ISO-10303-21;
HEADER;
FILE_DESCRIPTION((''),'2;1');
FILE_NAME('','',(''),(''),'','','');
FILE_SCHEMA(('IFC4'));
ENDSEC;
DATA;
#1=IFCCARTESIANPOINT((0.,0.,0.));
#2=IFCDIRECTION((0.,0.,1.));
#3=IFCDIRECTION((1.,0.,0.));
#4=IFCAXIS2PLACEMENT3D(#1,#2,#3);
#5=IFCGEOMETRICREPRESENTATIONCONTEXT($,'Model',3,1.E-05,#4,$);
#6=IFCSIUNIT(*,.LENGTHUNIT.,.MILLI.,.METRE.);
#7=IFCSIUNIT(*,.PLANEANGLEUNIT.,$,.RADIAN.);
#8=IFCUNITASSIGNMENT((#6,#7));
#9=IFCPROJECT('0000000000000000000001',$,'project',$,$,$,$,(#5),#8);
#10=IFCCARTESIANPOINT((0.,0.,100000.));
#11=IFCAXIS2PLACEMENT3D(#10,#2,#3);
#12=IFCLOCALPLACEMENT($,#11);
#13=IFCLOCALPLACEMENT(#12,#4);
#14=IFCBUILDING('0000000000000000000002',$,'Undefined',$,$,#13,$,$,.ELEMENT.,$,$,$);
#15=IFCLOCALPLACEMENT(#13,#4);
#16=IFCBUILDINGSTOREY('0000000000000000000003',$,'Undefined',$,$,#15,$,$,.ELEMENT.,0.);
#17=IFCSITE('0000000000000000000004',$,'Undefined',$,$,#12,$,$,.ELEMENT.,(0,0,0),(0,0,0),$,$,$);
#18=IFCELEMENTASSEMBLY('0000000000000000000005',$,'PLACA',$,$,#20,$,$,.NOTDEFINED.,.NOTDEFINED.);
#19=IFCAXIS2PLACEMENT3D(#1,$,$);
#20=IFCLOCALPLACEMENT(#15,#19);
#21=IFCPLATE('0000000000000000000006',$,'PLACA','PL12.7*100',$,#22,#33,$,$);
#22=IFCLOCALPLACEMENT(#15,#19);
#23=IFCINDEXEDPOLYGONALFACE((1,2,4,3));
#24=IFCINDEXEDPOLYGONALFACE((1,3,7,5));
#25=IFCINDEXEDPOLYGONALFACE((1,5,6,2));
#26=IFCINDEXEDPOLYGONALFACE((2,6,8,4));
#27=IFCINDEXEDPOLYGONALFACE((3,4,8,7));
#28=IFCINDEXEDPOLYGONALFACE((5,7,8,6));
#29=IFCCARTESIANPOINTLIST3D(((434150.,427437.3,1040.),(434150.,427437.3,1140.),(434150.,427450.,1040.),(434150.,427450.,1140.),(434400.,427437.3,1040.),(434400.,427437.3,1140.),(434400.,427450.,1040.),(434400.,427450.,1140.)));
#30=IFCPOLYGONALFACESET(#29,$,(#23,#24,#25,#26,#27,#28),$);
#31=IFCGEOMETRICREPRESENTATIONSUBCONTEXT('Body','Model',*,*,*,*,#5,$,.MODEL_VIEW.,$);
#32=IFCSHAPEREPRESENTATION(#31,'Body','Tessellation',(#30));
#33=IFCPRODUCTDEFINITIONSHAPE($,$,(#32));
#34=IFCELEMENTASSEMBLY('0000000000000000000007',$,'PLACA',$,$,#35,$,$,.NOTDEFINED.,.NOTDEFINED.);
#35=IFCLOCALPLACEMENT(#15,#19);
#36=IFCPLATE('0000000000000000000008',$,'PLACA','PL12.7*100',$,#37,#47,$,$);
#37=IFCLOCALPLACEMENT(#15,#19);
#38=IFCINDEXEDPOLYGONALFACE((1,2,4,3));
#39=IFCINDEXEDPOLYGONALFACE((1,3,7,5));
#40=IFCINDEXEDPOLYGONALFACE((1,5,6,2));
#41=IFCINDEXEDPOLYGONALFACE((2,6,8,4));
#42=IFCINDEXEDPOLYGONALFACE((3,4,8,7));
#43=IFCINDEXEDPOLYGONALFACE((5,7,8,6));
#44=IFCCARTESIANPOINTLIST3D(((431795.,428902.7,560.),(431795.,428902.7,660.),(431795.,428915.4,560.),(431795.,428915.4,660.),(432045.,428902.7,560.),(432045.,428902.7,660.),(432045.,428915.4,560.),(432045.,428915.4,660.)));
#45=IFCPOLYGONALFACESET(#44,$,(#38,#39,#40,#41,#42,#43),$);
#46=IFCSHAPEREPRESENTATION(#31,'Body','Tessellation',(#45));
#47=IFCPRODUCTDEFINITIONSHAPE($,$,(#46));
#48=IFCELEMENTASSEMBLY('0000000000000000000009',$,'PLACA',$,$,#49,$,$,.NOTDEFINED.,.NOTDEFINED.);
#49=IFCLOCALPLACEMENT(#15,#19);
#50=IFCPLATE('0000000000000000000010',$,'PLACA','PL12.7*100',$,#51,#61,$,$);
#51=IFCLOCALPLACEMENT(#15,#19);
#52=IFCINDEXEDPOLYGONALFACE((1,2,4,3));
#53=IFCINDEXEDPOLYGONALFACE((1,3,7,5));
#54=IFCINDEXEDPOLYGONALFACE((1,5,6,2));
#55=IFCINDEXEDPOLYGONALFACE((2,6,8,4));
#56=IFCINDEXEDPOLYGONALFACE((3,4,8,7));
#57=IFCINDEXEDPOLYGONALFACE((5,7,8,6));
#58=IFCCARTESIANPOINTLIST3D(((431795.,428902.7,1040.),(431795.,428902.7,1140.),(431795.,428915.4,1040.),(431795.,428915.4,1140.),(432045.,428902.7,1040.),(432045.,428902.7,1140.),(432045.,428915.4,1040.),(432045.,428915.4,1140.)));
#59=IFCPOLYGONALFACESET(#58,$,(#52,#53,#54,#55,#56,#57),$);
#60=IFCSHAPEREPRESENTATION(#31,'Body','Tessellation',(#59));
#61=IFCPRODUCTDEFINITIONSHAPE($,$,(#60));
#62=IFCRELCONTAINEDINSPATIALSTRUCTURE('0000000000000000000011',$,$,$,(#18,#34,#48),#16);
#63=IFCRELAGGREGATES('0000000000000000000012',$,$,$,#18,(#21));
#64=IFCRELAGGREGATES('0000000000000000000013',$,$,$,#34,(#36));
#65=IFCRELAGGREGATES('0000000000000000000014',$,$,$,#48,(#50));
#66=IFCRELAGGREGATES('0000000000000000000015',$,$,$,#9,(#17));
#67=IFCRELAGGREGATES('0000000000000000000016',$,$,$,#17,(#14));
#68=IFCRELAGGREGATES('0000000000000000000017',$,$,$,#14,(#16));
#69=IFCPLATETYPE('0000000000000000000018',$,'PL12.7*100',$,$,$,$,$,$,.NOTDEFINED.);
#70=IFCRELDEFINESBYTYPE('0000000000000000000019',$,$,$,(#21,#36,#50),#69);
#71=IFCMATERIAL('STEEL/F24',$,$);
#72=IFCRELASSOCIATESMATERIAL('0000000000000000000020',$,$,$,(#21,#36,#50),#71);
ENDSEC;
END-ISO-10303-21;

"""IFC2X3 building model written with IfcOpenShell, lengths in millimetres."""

from ifc_helpers import new_model, si_unit, frame, origin_with_axes, place, context, subcontext, project, spatial, polyline, outline, extrude, material, type_object, element, aggregate, save


model = new_model("IFC2X3")

# Units and contexts
model_context = context("Model", 3, precision=1e-05, world=origin_with_axes())
body_context = subcontext(model_context, "Body", "Model", "MODEL_VIEW")
ifc_project = project(units=[si_unit("LENGTHUNIT", "METRE", prefix="MILLI"), si_unit("PLANEANGLEUNIT", "RADIAN")], contexts=[model_context])

# Site, building, storey
site_placement = place(None, frame((0.0, 0.0, 100000.0), z_axis=(0.0, 0.0, 1.0), x_axis=(1.0, 0.0, 0.0)))
site = spatial("IfcSite", under=ifc_project, at=site_placement, Name="Undefined", CompositionType="ELEMENT", RefLatitude=(0, 0, 0), RefLongitude=(0, 0, 0))
building_placement = place(site_placement, origin_with_axes())
building = spatial("IfcBuilding", under=site, at=building_placement, Name="Undefined", CompositionType="ELEMENT")
storey_placement = place(building_placement, origin_with_axes())
storey = spatial("IfcBuildingStorey", under=building, at=storey_placement, Name="Undefined", CompositionType="ELEMENT", Elevation=0.0)

# Element assemblies, plates
ifc_material_1 = material(Name="STEEL/F24")
plate_type = type_object("IfcPlateType", Name="PL12.7*100", PredefinedType="NOTDEFINED")
assembly_1_placement = place(storey_placement, origin_with_axes())
assembly_1 = element("IfcElementAssembly", 1, at=assembly_1_placement, inside=storey, Name="PLACA", AssemblyPlace="NOTDEFINED", PredefinedType="NOTDEFINED")
plate_1_placement = place(assembly_1_placement, frame((434150.0, 427443.6, 1140.0), z_axis=(0.0, 1.0, 0.0), x_axis=(1.0, 0.0, 0.0)))
plate_1 = element("IfcPlate", 2, at=plate_1_placement, type_object=plate_type, material=ifc_material_1, Name="PLACA", Description="PL12.7*100", context=body_context, shape_type="SweptSolid", body=[
    extrude(outline(polyline([(0.0, 0.0), (250.0, 0.0), (250.0, 100.0), (0.0, 100.0), (0.0, 0.0)])), frame((0.0, 0.0, -6.3), z_axis=(0.0, 0.0, 1.0), x_axis=(1.0, 0.0, 0.0)), (0.0, 0.0, 1.0), 12.7),
])
aggregate(assembly_1, [plate_1])
assembly_2_placement = place(storey_placement, origin_with_axes())
assembly_2 = element("IfcElementAssembly", 3, at=assembly_2_placement, inside=storey, Name="PLACA", AssemblyPlace="NOTDEFINED", PredefinedType="NOTDEFINED")
plate_2_placement = place(assembly_2_placement, frame((432045.0, 428909.1, 660.0), z_axis=(0.0, -1.0, 0.0), x_axis=(-1.0, 0.0, 0.0)))
plate_2 = element("IfcPlate", 4, at=plate_2_placement, type_object=plate_type, material=ifc_material_1, Name="PLACA", Description="PL12.7*100", context=body_context, shape_type="SweptSolid", body=[
    extrude(outline(polyline([(0.0, 0.0), (250.0, 0.0), (250.0, 100.0), (0.0, 100.0), (0.0, 0.0)])), frame((0.0, 0.0, -6.3), z_axis=(0.0, 0.0, 1.0), x_axis=(1.0, 0.0, 0.0)), (0.0, 0.0, 1.0), 12.7),
])
aggregate(assembly_2, [plate_2])
assembly_3_placement = place(storey_placement, origin_with_axes())
assembly_3 = element("IfcElementAssembly", 5, at=assembly_3_placement, inside=storey, Name="PLACA", AssemblyPlace="NOTDEFINED", PredefinedType="NOTDEFINED")
plate_3_placement = place(assembly_3_placement, frame((432045.0, 428909.1, 1140.0), z_axis=(0.0, -1.0, 0.0), x_axis=(-1.0, 0.0, 0.0)))
plate_3 = element("IfcPlate", 6, at=plate_3_placement, type_object=plate_type, material=ifc_material_1, Name="PLACA", Description="PL12.7*100", context=body_context, shape_type="SweptSolid", body=[
    extrude(outline(polyline([(0.0, 0.0), (250.0, 0.0), (250.0, 100.0), (0.0, 100.0), (0.0, 0.0)])), frame((0.0, 0.0, -6.3), z_axis=(0.0, 0.0, 1.0), x_axis=(1.0, 0.0, 0.0)), (0.0, 0.0, 1.0), 12.7),
])
aggregate(assembly_3, [plate_3])

save(model, "model.ifc")
